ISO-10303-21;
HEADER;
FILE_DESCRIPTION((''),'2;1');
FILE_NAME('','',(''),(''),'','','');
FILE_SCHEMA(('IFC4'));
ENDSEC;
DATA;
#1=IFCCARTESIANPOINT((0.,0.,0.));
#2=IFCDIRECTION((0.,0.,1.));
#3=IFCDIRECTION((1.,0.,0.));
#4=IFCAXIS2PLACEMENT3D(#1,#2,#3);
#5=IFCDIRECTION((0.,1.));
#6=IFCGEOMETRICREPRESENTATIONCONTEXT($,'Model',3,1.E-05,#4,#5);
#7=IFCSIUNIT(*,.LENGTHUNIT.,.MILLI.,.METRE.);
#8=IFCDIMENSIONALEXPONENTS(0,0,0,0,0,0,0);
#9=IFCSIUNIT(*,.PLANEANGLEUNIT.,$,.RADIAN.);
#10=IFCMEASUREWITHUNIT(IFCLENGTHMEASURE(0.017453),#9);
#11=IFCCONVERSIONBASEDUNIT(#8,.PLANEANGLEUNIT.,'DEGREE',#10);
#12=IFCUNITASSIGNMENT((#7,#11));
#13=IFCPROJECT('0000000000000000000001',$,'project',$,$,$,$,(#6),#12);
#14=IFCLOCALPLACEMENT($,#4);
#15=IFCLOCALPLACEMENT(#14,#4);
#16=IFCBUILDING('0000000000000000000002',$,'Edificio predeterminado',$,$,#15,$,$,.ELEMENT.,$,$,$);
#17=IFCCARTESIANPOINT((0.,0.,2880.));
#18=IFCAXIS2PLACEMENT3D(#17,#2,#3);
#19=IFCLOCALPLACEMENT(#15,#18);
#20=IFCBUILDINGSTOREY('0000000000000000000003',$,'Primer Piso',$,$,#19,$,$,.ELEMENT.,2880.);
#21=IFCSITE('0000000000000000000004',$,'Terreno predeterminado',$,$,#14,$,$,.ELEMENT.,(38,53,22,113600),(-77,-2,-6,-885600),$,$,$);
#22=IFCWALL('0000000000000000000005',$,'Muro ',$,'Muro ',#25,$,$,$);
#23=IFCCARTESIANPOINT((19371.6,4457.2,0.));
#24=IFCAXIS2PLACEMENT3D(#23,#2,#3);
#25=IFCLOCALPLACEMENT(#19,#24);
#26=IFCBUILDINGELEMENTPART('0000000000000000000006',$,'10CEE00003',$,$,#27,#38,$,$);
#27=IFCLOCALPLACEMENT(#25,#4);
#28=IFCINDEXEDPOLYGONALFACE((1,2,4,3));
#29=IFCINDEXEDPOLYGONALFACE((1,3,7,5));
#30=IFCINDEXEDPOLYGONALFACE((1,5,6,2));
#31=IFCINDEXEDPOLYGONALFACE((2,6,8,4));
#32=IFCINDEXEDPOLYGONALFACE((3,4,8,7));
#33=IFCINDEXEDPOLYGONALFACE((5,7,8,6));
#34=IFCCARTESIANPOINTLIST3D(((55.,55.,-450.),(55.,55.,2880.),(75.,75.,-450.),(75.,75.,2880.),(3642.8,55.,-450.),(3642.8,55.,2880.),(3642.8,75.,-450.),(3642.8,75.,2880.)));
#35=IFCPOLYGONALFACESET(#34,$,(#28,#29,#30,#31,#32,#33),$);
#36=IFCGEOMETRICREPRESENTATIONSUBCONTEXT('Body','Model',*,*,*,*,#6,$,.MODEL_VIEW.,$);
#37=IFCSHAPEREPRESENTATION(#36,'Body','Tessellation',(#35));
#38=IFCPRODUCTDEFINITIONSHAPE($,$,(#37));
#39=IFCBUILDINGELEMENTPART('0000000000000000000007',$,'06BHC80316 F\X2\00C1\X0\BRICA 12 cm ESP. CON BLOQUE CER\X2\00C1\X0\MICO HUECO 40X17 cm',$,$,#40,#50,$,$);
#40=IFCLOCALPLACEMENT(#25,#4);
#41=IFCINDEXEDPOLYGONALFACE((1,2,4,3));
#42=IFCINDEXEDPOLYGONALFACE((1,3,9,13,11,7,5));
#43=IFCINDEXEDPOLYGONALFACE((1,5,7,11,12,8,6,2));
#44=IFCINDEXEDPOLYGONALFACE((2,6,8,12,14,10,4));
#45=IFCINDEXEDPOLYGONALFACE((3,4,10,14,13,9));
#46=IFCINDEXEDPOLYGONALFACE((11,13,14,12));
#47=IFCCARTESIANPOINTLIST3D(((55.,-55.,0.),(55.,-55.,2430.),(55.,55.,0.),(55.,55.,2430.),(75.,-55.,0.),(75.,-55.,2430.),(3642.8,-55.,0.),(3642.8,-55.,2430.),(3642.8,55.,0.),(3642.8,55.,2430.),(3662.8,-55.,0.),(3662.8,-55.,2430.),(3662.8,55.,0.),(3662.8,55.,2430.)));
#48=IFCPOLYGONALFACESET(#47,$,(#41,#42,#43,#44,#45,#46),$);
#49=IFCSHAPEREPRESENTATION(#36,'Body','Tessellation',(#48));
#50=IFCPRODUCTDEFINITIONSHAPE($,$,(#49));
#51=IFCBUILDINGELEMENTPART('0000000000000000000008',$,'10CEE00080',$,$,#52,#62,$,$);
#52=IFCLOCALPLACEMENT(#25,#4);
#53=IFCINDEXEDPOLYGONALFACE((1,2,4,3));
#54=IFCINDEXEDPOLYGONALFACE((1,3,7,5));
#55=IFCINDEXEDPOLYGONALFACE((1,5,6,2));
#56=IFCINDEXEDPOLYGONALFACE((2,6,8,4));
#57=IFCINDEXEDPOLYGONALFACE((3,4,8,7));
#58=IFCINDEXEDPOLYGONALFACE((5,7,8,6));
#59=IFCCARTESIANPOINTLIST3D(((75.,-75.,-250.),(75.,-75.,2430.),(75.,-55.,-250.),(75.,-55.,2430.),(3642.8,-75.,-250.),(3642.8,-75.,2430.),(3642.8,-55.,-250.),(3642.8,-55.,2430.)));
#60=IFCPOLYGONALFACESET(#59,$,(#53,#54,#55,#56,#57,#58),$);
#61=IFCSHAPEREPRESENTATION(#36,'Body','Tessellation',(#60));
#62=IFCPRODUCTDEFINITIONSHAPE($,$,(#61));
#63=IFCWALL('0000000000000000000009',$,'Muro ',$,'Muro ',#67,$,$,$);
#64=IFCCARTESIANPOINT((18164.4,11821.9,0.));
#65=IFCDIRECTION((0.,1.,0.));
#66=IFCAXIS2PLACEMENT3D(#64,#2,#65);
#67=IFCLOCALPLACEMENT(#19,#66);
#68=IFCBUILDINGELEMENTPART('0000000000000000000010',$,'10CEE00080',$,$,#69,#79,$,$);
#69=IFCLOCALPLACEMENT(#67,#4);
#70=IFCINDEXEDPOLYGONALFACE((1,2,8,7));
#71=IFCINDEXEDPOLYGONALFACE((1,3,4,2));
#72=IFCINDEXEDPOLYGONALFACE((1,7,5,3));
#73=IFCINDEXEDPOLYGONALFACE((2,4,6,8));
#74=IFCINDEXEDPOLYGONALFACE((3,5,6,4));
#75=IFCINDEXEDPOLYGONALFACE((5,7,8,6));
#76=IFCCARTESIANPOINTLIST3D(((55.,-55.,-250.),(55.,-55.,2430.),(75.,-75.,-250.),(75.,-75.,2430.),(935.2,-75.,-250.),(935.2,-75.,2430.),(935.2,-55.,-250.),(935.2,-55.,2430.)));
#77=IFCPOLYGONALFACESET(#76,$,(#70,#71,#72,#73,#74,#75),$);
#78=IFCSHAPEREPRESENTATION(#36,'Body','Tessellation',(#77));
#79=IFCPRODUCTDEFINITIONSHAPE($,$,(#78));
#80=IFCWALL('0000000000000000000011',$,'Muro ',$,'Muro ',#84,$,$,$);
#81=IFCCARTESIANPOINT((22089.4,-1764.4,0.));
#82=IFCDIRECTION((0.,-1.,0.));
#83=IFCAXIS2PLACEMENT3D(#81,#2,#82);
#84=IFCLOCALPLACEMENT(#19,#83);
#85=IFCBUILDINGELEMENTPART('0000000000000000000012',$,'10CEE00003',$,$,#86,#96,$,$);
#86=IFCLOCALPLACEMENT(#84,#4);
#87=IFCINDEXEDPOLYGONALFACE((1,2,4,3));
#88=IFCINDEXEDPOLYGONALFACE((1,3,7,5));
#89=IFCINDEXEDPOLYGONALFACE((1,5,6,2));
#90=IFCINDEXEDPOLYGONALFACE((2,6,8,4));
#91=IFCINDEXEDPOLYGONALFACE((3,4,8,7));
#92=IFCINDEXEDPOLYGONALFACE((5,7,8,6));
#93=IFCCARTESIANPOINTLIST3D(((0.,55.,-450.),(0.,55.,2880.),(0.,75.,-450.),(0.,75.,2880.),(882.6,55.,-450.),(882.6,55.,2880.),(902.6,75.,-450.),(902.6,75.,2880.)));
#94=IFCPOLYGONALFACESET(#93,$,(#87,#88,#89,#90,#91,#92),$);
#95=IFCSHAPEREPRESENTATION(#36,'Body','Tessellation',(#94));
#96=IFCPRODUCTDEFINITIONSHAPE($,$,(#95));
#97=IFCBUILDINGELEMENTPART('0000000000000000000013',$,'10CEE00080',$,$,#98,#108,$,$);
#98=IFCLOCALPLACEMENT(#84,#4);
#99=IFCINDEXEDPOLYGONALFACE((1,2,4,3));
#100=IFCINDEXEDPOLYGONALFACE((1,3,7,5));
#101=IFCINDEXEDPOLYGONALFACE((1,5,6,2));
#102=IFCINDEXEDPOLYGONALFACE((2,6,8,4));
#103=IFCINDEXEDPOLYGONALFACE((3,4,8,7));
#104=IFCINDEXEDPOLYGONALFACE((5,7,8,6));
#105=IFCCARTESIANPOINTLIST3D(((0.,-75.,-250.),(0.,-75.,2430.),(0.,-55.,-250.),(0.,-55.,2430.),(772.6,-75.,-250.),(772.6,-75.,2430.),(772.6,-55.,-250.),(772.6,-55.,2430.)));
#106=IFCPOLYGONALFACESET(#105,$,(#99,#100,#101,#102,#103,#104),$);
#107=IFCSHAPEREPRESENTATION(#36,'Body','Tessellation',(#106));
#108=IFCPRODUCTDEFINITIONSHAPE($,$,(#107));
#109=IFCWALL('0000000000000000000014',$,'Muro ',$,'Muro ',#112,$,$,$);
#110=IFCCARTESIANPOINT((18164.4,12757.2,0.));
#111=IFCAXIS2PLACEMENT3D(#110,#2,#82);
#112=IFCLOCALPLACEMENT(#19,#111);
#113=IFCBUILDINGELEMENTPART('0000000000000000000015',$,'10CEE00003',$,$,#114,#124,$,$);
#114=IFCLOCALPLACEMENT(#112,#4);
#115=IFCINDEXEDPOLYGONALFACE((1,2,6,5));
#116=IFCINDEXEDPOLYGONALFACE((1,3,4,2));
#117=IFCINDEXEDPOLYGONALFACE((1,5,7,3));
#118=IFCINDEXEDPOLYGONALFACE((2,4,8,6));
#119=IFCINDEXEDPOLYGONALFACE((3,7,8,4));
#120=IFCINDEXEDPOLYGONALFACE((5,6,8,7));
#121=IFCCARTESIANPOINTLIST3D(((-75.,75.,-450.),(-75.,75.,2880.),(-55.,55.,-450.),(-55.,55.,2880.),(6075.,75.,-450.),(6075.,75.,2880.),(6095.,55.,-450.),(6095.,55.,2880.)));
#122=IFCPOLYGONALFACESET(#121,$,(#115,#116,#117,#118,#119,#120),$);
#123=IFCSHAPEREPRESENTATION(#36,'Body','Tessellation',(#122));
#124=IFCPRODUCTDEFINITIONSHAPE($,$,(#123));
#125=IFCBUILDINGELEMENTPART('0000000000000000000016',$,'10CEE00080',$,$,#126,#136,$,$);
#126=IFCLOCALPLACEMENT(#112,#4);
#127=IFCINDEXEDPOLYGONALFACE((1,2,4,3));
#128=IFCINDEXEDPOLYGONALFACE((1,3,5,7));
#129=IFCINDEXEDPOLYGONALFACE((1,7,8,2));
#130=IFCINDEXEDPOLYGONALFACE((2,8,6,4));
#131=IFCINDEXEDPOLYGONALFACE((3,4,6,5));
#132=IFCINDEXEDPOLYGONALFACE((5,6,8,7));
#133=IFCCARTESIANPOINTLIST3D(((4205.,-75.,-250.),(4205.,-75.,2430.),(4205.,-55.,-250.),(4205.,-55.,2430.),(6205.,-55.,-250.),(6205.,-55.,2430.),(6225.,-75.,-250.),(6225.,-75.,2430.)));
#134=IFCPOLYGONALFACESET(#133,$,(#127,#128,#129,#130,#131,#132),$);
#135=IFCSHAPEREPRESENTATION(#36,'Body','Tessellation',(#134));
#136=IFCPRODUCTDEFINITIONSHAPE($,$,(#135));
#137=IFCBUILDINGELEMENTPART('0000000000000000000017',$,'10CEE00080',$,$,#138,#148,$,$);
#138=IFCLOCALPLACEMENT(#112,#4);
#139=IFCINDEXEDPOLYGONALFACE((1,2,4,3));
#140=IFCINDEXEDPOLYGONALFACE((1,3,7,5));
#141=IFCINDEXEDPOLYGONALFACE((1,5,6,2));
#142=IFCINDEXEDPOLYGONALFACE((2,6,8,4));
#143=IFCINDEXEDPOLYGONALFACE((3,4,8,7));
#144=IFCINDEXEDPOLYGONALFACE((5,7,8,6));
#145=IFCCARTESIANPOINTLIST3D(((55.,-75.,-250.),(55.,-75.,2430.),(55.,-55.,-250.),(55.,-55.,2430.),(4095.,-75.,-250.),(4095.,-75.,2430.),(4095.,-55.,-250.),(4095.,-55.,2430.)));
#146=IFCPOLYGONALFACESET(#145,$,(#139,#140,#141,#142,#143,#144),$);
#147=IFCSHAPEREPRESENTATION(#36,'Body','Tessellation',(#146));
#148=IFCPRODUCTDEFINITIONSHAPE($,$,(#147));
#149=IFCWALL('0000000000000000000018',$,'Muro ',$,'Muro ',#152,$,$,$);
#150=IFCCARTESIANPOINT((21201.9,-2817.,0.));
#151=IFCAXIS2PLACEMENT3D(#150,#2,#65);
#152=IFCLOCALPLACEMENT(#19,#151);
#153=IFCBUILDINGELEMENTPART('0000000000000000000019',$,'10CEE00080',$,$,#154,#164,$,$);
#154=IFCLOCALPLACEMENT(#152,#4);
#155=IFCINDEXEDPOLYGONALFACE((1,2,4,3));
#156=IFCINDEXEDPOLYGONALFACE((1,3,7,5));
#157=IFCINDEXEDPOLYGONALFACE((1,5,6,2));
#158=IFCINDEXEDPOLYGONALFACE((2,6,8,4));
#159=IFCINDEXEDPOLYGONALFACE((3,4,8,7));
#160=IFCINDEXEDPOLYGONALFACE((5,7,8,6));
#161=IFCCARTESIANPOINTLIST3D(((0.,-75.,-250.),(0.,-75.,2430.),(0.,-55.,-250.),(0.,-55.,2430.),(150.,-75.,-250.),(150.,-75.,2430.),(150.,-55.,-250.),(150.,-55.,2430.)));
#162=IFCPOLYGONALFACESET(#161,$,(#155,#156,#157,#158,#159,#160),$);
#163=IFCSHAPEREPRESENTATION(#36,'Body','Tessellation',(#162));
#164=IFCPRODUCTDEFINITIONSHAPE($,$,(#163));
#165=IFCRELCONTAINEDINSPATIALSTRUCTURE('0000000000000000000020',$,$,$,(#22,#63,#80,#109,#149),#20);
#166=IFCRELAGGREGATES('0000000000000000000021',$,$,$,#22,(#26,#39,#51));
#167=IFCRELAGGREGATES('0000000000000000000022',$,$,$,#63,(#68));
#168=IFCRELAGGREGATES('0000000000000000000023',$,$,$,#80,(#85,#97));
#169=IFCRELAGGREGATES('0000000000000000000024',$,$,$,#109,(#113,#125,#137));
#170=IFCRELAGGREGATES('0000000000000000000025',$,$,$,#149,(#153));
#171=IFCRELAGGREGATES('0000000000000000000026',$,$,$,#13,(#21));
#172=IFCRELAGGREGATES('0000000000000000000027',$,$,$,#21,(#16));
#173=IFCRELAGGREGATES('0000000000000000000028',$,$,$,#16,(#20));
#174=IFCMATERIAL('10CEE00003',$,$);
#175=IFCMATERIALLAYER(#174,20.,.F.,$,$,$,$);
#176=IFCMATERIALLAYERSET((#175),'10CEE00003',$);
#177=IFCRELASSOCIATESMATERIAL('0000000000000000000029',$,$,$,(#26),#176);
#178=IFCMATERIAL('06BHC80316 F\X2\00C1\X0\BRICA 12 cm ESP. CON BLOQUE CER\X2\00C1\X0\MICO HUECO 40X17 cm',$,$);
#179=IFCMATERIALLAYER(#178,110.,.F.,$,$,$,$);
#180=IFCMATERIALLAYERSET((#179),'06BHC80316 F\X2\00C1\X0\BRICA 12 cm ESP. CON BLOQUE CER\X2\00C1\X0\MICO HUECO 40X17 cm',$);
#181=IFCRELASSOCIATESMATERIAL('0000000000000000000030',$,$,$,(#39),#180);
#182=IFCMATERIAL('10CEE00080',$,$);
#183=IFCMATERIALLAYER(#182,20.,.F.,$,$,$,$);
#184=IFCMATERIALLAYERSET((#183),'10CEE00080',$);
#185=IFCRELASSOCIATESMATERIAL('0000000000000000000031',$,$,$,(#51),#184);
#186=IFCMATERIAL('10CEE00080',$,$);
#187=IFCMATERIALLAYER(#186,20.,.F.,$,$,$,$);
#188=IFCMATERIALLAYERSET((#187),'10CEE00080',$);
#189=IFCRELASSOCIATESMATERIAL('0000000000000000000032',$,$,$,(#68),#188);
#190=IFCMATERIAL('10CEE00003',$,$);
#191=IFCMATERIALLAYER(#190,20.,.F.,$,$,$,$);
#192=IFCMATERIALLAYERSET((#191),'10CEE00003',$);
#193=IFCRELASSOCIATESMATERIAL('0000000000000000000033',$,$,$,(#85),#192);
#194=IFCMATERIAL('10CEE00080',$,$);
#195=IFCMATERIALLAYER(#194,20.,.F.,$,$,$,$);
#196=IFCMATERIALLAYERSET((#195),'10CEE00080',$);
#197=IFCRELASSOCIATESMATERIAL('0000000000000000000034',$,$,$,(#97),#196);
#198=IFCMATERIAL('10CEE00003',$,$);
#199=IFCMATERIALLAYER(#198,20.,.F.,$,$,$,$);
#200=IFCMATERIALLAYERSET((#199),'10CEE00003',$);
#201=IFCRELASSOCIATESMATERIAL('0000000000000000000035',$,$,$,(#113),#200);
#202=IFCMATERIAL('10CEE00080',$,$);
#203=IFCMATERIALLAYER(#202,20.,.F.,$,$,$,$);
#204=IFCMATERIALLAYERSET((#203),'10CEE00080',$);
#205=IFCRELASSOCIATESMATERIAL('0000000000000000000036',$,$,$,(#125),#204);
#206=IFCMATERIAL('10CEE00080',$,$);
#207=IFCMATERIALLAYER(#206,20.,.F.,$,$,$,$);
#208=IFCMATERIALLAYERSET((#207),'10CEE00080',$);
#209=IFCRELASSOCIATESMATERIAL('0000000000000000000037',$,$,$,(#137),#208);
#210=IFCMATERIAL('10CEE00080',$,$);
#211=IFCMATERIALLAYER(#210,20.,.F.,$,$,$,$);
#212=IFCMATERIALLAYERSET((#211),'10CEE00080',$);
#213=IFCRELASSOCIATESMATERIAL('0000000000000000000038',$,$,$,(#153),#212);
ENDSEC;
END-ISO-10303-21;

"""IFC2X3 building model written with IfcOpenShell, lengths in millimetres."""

from ifc_helpers import new_model, entity, si_unit, converted_unit, direction, frame, origin_with_axes, place, context, subcontext, project, spatial, polyline, outline, extrude, clip, bounded_halfspace, material, layer, layer_set, layer_usage, element, aggregate, save


model = new_model("IFC2X3")

# Units and contexts
model_context = context("Model", 3, precision=1e-05, world=origin_with_axes(), true_north=direction((0.0, 1.0)))
body_context = subcontext(model_context, "Body", "Model", "MODEL_VIEW")
ifc_project = project(units=[si_unit("LENGTHUNIT", "METRE", prefix="MILLI"), converted_unit("PLANEANGLEUNIT", "DEGREE", entity("IfcLengthMeasure", 0.017453), si_unit("PLANEANGLEUNIT", "RADIAN"), dimensions=[0, 0, 0, 0, 0, 0, 0])], contexts=[model_context])

# Site, building, storey
site_placement = place(None, origin_with_axes())
site = spatial("IfcSite", under=ifc_project, at=site_placement, Name="Terreno predeterminado", CompositionType="ELEMENT", RefLatitude=(38, 53, 22, 113600), RefLongitude=(-77, -2, -6, -885600))
building_placement = place(site_placement, origin_with_axes())
building = spatial("IfcBuilding", under=site, at=building_placement, Name="Edificio predeterminado", CompositionType="ELEMENT")
storey_placement = place(building_placement, frame((0.0, 0.0, 2880.0), z_axis=(0.0, 0.0, 1.0), x_axis=(1.0, 0.0, 0.0)))
storey = spatial("IfcBuildingStorey", under=building, at=storey_placement, Name="Primer Piso", CompositionType="ELEMENT", Elevation=2880.0)

# Walls, building element parts
wall_1_placement = place(storey_placement, frame((19371.6, 4457.2, 0.0), z_axis=(0.0, 0.0, 1.0), x_axis=(1.0, 0.0, 0.0)))
wall_1 = element("IfcWall", 1, at=wall_1_placement, inside=storey, Name="Muro ", ObjectType="Muro ")
ifc_material_1 = material(Name="10CEE00003")
ifc_layer_1 = layer(ifc_material_1, 20.0, ventilated=False)
ifc_layer_set_1 = layer_set([ifc_layer_1], Name="10CEE00003")
ifc_layer_usage_1 = layer_usage(ifc_layer_set_1, "AXIS2", "NEGATIVE", -75.0)
building_element_part_1_placement = place(wall_1_placement, origin_with_axes())
building_element_part_1 = element("IfcBuildingElementPart", 2, at=building_element_part_1_placement, material=ifc_layer_usage_1, Name="10CEE00003", context=body_context, shape_type="SweptSolid", body=[
    extrude(outline(polyline([(3642.8, 75.0), (3642.8, 55.0), (55.0, 55.0), (75.0, 75.0), (3642.8, 75.0)])), frame((0.0, 0.0, -450.0), z_axis=(0.0, 0.0, 1.0), x_axis=(1.0, 0.0, 0.0)), (0.0, 0.0, 1.0), 3330.0),
])
ifc_material_2 = material(Name="06BHC80316 FÁBRICA 12 cm ESP. CON BLOQUE CERÁMICO HUECO 40X17 cm")
ifc_layer_2 = layer(ifc_material_2, 110.0, ventilated=False)
ifc_layer_set_2 = layer_set([ifc_layer_2], Name="06BHC80316 FÁBRICA 12 cm ESP. CON BLOQUE CERÁMICO HUECO 40X17 cm")
ifc_layer_usage_2 = layer_usage(ifc_layer_set_2, "AXIS2", "NEGATIVE", -55.0)
building_element_part_2_placement = place(wall_1_placement, origin_with_axes())
building_element_part_2 = element("IfcBuildingElementPart", 3, at=building_element_part_2_placement, material=ifc_layer_usage_2, Name="06BHC80316 FÁBRICA 12 cm ESP. CON BLOQUE CERÁMICO HUECO 40X17 cm", context=body_context, shape_type="SweptSolid", body=[
    extrude(outline(polyline([(3662.8, 55.0), (3662.8, -55.0), (3642.8, -55.0), (75.0, -55.0), (55.0, -55.0), (55.0, 55.0), (3642.8, 55.0), (3662.8, 55.0)])), origin_with_axes(), (0.0, 0.0, 1.0), 2430.0),
])
ifc_material_3 = material(Name="10CEE00080")
ifc_layer_3 = layer(ifc_material_3, 20.0, ventilated=False)
ifc_layer_set_3 = layer_set([ifc_layer_3], Name="10CEE00080")
ifc_layer_usage_3 = layer_usage(ifc_layer_set_3, "AXIS2", "NEGATIVE", 55.0)
building_element_part_3_placement = place(wall_1_placement, origin_with_axes())
building_element_part_3 = element("IfcBuildingElementPart", 4, at=building_element_part_3_placement, material=ifc_layer_usage_3, Name="10CEE00080", context=body_context, shape_type="SweptSolid", body=[
    extrude(outline(polyline([(3642.8, -55.0), (3642.8, -75.0), (75.0, -75.0), (75.0, -55.0), (3642.8, -55.0)])), frame((0.0, 0.0, -250.0), z_axis=(0.0, 0.0, 1.0), x_axis=(1.0, 0.0, 0.0)), (0.0, 0.0, 1.0), 2680.0),
])
aggregate(wall_1, [building_element_part_1, building_element_part_2, building_element_part_3])
wall_2_placement = place(storey_placement, frame((18164.4, 11821.9, 0.0), z_axis=(0.0, 0.0, 1.0), x_axis=(0.0, 1.0, 0.0)))
wall_2 = element("IfcWall", 5, at=wall_2_placement, inside=storey, Name="Muro ", ObjectType="Muro ")
ifc_material_4 = material(Name="10CEE00080")
ifc_layer_4 = layer(ifc_material_4, 20.0, ventilated=False)
ifc_layer_set_4 = layer_set([ifc_layer_4], Name="10CEE00080")
ifc_layer_usage_4 = layer_usage(ifc_layer_set_4, "AXIS2", "NEGATIVE", 55.0)
building_element_part_4_placement = place(wall_2_placement, origin_with_axes())
building_element_part_4 = element("IfcBuildingElementPart", 6, at=building_element_part_4_placement, material=ifc_layer_usage_4, Name="10CEE00080", context=body_context, shape_type="SweptSolid", body=[
    extrude(outline(polyline([(935.2, -55.0), (935.2, -75.0), (75.0, -75.0), (55.0, -55.0), (935.2, -55.0)])), frame((0.0, 0.0, -250.0), z_axis=(0.0, 0.0, 1.0), x_axis=(1.0, 0.0, 0.0)), (0.0, 0.0, 1.0), 2680.0),
])
aggregate(wall_2, [building_element_part_4])
wall_3_placement = place(storey_placement, frame((22089.4, -1764.4, 0.0), z_axis=(0.0, 0.0, 1.0), x_axis=(0.0, -1.0, 0.0)))
wall_3 = element("IfcWall", 7, at=wall_3_placement, inside=storey, Name="Muro ", ObjectType="Muro ")
ifc_material_5 = material(Name="10CEE00003")
ifc_layer_5 = layer(ifc_material_5, 20.0, ventilated=False)
ifc_layer_set_5 = layer_set([ifc_layer_5], Name="10CEE00003")
ifc_layer_usage_5 = layer_usage(ifc_layer_set_5, "AXIS2", "NEGATIVE", -75.0)
building_element_part_5_placement = place(wall_3_placement, origin_with_axes())
building_element_part_5 = element("IfcBuildingElementPart", 8, at=building_element_part_5_placement, material=ifc_layer_usage_5, Name="10CEE00003", context=body_context, shape_type="SweptSolid", body=[
    extrude(outline(polyline([(902.6, 75.0), (882.6, 55.0), (0.0, 55.0), (0.0, 75.0), (902.6, 75.0)])), frame((0.0, 0.0, -450.0), z_axis=(0.0, 0.0, 1.0), x_axis=(1.0, 0.0, 0.0)), (0.0, 0.0, 1.0), 3330.0),
])
ifc_material_6 = material(Name="10CEE00080")
ifc_layer_6 = layer(ifc_material_6, 20.0, ventilated=False)
ifc_layer_set_6 = layer_set([ifc_layer_6], Name="10CEE00080")
ifc_layer_usage_6 = layer_usage(ifc_layer_set_6, "AXIS2", "NEGATIVE", 55.0)
building_element_part_6_placement = place(wall_3_placement, origin_with_axes())
building_element_part_6 = element("IfcBuildingElementPart", 9, at=building_element_part_6_placement, material=ifc_layer_usage_6, Name="10CEE00080", context=body_context, shape_type="SweptSolid", body=[
    extrude(outline(polyline([(772.6, -55.0), (772.6, -75.0), (0.0, -75.0), (0.0, -55.0), (772.6, -55.0)])), frame((0.0, 0.0, -250.0), z_axis=(0.0, 0.0, 1.0), x_axis=(1.0, 0.0, 0.0)), (0.0, 0.0, 1.0), 2680.0),
])
aggregate(wall_3, [building_element_part_5, building_element_part_6])
wall_4_placement = place(storey_placement, frame((18164.4, 12757.2, 0.0), z_axis=(0.0, 0.0, 1.0), x_axis=(0.0, -1.0, 0.0)))
wall_4 = element("IfcWall", 10, at=wall_4_placement, inside=storey, Name="Muro ", ObjectType="Muro ")
ifc_material_7 = material(Name="10CEE00003")
ifc_layer_7 = layer(ifc_material_7, 20.0, ventilated=False)
ifc_layer_set_7 = layer_set([ifc_layer_7], Name="10CEE00003")
ifc_layer_usage_7 = layer_usage(ifc_layer_set_7, "AXIS2", "NEGATIVE", -75.0)
building_element_part_7_placement = place(wall_4_placement, origin_with_axes())
building_element_part_7 = element("IfcBuildingElementPart", 11, at=building_element_part_7_placement, material=ifc_layer_usage_7, Name="10CEE00003", context=body_context, shape_type="SweptSolid", body=[
    extrude(outline(polyline([(6075.0, 75.0), (6095.0, 55.0), (-55.0, 55.0), (-75.0, 75.0), (6075.0, 75.0)])), frame((0.0, 0.0, -450.0), z_axis=(0.0, 0.0, 1.0), x_axis=(1.0, 0.0, 0.0)), (0.0, 0.0, 1.0), 3330.0),
])
ifc_material_8 = material(Name="10CEE00080")
ifc_layer_8 = layer(ifc_material_8, 20.0, ventilated=False)
ifc_layer_set_8 = layer_set([ifc_layer_8], Name="10CEE00080")
ifc_layer_usage_8 = layer_usage(ifc_layer_set_8, "AXIS2", "NEGATIVE", 55.0)
building_element_part_8_placement = place(wall_4_placement, origin_with_axes())
building_element_part_8 = element("IfcBuildingElementPart", 12, at=building_element_part_8_placement, material=ifc_layer_usage_8, Name="10CEE00080", context=body_context, shape_type="SweptSolid", body=[
    extrude(outline(polyline([(6205.0, -55.0), (6225.0, -75.0), (4205.0, -75.0), (4205.0, -55.0), (6205.0, -55.0)])), frame((0.0, 0.0, -250.0), z_axis=(0.0, 0.0, 1.0), x_axis=(1.0, 0.0, 0.0)), (0.0, 0.0, 1.0), 2680.0),
])
ifc_material_9 = material(Name="10CEE00080")
ifc_layer_9 = layer(ifc_material_9, 20.0, ventilated=False)
ifc_layer_set_9 = layer_set([ifc_layer_9], Name="10CEE00080")
ifc_layer_usage_9 = layer_usage(ifc_layer_set_9, "AXIS2", "NEGATIVE", 55.0)
building_element_part_9_placement = place(wall_4_placement, origin_with_axes())
building_element_part_9 = element("IfcBuildingElementPart", 13, at=building_element_part_9_placement, material=ifc_layer_usage_9, Name="10CEE00080", context=body_context, shape_type="SweptSolid", body=[
    extrude(outline(polyline([(4095.0, -55.0), (4095.0, -75.0), (55.0, -75.0), (55.0, -55.0), (4095.0, -55.0)])), frame((0.0, 0.0, -250.0), z_axis=(0.0, 0.0, 1.0), x_axis=(1.0, 0.0, 0.0)), (0.0, 0.0, 1.0), 2680.0),
])
aggregate(wall_4, [building_element_part_7, building_element_part_8, building_element_part_9])
wall_5_placement = place(storey_placement, frame((21201.9, -2817.0, 0.0), z_axis=(0.0, 0.0, 1.0), x_axis=(0.0, 1.0, 0.0)))
wall_5 = element("IfcWall", 14, at=wall_5_placement, inside=storey, Name="Muro ", ObjectType="Muro ")
ifc_material_10 = material(Name="10CEE00080")
ifc_layer_10 = layer(ifc_material_10, 20.0, ventilated=False)
ifc_layer_set_10 = layer_set([ifc_layer_10], Name="10CEE00080")
ifc_layer_usage_10 = layer_usage(ifc_layer_set_10, "AXIS2", "NEGATIVE", 55.0)
building_element_part_10_placement = place(wall_5_placement, origin_with_axes())
building_element_part_10 = element("IfcBuildingElementPart", 15, at=building_element_part_10_placement, material=ifc_layer_usage_10, Name="10CEE00080", context=body_context, shape_type="Clipping", body=[
    clip(clip(extrude(outline(polyline([(150.0, -55.0), (150.0, -75.0), (0.0, -75.0), (0.0, -55.0), (150.0, -55.0)])), frame((0.0, 0.0, -250.0), z_axis=(0.0, 0.0, 1.0), x_axis=(1.0, 0.0, 0.0)), (0.0, 0.0, 1.0), 2680.0), bounded_halfspace(frame((0.0, 0.0, -250.0), z_axis=(0.0, 0.0, 1.0), x_axis=(1.0, 0.0, 0.0)), True, origin_with_axes(), polyline([(-150.0, -150.0), (375.0, -150.0), (375.0, 150.0), (-150.0, 150.0), (-150.0, -150.0)]))), bounded_halfspace(frame((0.0, 0.0, 2430.0), z_axis=(0.0, 0.0, 1.0), x_axis=(1.0, 0.0, 0.0)), False, origin_with_axes(), polyline([(-150.0, -150.0), (375.0, -150.0), (375.0, 150.0), (-150.0, 150.0), (-150.0, -150.0)]))),
])
aggregate(wall_5, [building_element_part_10])

save(model, "model.ifc")
